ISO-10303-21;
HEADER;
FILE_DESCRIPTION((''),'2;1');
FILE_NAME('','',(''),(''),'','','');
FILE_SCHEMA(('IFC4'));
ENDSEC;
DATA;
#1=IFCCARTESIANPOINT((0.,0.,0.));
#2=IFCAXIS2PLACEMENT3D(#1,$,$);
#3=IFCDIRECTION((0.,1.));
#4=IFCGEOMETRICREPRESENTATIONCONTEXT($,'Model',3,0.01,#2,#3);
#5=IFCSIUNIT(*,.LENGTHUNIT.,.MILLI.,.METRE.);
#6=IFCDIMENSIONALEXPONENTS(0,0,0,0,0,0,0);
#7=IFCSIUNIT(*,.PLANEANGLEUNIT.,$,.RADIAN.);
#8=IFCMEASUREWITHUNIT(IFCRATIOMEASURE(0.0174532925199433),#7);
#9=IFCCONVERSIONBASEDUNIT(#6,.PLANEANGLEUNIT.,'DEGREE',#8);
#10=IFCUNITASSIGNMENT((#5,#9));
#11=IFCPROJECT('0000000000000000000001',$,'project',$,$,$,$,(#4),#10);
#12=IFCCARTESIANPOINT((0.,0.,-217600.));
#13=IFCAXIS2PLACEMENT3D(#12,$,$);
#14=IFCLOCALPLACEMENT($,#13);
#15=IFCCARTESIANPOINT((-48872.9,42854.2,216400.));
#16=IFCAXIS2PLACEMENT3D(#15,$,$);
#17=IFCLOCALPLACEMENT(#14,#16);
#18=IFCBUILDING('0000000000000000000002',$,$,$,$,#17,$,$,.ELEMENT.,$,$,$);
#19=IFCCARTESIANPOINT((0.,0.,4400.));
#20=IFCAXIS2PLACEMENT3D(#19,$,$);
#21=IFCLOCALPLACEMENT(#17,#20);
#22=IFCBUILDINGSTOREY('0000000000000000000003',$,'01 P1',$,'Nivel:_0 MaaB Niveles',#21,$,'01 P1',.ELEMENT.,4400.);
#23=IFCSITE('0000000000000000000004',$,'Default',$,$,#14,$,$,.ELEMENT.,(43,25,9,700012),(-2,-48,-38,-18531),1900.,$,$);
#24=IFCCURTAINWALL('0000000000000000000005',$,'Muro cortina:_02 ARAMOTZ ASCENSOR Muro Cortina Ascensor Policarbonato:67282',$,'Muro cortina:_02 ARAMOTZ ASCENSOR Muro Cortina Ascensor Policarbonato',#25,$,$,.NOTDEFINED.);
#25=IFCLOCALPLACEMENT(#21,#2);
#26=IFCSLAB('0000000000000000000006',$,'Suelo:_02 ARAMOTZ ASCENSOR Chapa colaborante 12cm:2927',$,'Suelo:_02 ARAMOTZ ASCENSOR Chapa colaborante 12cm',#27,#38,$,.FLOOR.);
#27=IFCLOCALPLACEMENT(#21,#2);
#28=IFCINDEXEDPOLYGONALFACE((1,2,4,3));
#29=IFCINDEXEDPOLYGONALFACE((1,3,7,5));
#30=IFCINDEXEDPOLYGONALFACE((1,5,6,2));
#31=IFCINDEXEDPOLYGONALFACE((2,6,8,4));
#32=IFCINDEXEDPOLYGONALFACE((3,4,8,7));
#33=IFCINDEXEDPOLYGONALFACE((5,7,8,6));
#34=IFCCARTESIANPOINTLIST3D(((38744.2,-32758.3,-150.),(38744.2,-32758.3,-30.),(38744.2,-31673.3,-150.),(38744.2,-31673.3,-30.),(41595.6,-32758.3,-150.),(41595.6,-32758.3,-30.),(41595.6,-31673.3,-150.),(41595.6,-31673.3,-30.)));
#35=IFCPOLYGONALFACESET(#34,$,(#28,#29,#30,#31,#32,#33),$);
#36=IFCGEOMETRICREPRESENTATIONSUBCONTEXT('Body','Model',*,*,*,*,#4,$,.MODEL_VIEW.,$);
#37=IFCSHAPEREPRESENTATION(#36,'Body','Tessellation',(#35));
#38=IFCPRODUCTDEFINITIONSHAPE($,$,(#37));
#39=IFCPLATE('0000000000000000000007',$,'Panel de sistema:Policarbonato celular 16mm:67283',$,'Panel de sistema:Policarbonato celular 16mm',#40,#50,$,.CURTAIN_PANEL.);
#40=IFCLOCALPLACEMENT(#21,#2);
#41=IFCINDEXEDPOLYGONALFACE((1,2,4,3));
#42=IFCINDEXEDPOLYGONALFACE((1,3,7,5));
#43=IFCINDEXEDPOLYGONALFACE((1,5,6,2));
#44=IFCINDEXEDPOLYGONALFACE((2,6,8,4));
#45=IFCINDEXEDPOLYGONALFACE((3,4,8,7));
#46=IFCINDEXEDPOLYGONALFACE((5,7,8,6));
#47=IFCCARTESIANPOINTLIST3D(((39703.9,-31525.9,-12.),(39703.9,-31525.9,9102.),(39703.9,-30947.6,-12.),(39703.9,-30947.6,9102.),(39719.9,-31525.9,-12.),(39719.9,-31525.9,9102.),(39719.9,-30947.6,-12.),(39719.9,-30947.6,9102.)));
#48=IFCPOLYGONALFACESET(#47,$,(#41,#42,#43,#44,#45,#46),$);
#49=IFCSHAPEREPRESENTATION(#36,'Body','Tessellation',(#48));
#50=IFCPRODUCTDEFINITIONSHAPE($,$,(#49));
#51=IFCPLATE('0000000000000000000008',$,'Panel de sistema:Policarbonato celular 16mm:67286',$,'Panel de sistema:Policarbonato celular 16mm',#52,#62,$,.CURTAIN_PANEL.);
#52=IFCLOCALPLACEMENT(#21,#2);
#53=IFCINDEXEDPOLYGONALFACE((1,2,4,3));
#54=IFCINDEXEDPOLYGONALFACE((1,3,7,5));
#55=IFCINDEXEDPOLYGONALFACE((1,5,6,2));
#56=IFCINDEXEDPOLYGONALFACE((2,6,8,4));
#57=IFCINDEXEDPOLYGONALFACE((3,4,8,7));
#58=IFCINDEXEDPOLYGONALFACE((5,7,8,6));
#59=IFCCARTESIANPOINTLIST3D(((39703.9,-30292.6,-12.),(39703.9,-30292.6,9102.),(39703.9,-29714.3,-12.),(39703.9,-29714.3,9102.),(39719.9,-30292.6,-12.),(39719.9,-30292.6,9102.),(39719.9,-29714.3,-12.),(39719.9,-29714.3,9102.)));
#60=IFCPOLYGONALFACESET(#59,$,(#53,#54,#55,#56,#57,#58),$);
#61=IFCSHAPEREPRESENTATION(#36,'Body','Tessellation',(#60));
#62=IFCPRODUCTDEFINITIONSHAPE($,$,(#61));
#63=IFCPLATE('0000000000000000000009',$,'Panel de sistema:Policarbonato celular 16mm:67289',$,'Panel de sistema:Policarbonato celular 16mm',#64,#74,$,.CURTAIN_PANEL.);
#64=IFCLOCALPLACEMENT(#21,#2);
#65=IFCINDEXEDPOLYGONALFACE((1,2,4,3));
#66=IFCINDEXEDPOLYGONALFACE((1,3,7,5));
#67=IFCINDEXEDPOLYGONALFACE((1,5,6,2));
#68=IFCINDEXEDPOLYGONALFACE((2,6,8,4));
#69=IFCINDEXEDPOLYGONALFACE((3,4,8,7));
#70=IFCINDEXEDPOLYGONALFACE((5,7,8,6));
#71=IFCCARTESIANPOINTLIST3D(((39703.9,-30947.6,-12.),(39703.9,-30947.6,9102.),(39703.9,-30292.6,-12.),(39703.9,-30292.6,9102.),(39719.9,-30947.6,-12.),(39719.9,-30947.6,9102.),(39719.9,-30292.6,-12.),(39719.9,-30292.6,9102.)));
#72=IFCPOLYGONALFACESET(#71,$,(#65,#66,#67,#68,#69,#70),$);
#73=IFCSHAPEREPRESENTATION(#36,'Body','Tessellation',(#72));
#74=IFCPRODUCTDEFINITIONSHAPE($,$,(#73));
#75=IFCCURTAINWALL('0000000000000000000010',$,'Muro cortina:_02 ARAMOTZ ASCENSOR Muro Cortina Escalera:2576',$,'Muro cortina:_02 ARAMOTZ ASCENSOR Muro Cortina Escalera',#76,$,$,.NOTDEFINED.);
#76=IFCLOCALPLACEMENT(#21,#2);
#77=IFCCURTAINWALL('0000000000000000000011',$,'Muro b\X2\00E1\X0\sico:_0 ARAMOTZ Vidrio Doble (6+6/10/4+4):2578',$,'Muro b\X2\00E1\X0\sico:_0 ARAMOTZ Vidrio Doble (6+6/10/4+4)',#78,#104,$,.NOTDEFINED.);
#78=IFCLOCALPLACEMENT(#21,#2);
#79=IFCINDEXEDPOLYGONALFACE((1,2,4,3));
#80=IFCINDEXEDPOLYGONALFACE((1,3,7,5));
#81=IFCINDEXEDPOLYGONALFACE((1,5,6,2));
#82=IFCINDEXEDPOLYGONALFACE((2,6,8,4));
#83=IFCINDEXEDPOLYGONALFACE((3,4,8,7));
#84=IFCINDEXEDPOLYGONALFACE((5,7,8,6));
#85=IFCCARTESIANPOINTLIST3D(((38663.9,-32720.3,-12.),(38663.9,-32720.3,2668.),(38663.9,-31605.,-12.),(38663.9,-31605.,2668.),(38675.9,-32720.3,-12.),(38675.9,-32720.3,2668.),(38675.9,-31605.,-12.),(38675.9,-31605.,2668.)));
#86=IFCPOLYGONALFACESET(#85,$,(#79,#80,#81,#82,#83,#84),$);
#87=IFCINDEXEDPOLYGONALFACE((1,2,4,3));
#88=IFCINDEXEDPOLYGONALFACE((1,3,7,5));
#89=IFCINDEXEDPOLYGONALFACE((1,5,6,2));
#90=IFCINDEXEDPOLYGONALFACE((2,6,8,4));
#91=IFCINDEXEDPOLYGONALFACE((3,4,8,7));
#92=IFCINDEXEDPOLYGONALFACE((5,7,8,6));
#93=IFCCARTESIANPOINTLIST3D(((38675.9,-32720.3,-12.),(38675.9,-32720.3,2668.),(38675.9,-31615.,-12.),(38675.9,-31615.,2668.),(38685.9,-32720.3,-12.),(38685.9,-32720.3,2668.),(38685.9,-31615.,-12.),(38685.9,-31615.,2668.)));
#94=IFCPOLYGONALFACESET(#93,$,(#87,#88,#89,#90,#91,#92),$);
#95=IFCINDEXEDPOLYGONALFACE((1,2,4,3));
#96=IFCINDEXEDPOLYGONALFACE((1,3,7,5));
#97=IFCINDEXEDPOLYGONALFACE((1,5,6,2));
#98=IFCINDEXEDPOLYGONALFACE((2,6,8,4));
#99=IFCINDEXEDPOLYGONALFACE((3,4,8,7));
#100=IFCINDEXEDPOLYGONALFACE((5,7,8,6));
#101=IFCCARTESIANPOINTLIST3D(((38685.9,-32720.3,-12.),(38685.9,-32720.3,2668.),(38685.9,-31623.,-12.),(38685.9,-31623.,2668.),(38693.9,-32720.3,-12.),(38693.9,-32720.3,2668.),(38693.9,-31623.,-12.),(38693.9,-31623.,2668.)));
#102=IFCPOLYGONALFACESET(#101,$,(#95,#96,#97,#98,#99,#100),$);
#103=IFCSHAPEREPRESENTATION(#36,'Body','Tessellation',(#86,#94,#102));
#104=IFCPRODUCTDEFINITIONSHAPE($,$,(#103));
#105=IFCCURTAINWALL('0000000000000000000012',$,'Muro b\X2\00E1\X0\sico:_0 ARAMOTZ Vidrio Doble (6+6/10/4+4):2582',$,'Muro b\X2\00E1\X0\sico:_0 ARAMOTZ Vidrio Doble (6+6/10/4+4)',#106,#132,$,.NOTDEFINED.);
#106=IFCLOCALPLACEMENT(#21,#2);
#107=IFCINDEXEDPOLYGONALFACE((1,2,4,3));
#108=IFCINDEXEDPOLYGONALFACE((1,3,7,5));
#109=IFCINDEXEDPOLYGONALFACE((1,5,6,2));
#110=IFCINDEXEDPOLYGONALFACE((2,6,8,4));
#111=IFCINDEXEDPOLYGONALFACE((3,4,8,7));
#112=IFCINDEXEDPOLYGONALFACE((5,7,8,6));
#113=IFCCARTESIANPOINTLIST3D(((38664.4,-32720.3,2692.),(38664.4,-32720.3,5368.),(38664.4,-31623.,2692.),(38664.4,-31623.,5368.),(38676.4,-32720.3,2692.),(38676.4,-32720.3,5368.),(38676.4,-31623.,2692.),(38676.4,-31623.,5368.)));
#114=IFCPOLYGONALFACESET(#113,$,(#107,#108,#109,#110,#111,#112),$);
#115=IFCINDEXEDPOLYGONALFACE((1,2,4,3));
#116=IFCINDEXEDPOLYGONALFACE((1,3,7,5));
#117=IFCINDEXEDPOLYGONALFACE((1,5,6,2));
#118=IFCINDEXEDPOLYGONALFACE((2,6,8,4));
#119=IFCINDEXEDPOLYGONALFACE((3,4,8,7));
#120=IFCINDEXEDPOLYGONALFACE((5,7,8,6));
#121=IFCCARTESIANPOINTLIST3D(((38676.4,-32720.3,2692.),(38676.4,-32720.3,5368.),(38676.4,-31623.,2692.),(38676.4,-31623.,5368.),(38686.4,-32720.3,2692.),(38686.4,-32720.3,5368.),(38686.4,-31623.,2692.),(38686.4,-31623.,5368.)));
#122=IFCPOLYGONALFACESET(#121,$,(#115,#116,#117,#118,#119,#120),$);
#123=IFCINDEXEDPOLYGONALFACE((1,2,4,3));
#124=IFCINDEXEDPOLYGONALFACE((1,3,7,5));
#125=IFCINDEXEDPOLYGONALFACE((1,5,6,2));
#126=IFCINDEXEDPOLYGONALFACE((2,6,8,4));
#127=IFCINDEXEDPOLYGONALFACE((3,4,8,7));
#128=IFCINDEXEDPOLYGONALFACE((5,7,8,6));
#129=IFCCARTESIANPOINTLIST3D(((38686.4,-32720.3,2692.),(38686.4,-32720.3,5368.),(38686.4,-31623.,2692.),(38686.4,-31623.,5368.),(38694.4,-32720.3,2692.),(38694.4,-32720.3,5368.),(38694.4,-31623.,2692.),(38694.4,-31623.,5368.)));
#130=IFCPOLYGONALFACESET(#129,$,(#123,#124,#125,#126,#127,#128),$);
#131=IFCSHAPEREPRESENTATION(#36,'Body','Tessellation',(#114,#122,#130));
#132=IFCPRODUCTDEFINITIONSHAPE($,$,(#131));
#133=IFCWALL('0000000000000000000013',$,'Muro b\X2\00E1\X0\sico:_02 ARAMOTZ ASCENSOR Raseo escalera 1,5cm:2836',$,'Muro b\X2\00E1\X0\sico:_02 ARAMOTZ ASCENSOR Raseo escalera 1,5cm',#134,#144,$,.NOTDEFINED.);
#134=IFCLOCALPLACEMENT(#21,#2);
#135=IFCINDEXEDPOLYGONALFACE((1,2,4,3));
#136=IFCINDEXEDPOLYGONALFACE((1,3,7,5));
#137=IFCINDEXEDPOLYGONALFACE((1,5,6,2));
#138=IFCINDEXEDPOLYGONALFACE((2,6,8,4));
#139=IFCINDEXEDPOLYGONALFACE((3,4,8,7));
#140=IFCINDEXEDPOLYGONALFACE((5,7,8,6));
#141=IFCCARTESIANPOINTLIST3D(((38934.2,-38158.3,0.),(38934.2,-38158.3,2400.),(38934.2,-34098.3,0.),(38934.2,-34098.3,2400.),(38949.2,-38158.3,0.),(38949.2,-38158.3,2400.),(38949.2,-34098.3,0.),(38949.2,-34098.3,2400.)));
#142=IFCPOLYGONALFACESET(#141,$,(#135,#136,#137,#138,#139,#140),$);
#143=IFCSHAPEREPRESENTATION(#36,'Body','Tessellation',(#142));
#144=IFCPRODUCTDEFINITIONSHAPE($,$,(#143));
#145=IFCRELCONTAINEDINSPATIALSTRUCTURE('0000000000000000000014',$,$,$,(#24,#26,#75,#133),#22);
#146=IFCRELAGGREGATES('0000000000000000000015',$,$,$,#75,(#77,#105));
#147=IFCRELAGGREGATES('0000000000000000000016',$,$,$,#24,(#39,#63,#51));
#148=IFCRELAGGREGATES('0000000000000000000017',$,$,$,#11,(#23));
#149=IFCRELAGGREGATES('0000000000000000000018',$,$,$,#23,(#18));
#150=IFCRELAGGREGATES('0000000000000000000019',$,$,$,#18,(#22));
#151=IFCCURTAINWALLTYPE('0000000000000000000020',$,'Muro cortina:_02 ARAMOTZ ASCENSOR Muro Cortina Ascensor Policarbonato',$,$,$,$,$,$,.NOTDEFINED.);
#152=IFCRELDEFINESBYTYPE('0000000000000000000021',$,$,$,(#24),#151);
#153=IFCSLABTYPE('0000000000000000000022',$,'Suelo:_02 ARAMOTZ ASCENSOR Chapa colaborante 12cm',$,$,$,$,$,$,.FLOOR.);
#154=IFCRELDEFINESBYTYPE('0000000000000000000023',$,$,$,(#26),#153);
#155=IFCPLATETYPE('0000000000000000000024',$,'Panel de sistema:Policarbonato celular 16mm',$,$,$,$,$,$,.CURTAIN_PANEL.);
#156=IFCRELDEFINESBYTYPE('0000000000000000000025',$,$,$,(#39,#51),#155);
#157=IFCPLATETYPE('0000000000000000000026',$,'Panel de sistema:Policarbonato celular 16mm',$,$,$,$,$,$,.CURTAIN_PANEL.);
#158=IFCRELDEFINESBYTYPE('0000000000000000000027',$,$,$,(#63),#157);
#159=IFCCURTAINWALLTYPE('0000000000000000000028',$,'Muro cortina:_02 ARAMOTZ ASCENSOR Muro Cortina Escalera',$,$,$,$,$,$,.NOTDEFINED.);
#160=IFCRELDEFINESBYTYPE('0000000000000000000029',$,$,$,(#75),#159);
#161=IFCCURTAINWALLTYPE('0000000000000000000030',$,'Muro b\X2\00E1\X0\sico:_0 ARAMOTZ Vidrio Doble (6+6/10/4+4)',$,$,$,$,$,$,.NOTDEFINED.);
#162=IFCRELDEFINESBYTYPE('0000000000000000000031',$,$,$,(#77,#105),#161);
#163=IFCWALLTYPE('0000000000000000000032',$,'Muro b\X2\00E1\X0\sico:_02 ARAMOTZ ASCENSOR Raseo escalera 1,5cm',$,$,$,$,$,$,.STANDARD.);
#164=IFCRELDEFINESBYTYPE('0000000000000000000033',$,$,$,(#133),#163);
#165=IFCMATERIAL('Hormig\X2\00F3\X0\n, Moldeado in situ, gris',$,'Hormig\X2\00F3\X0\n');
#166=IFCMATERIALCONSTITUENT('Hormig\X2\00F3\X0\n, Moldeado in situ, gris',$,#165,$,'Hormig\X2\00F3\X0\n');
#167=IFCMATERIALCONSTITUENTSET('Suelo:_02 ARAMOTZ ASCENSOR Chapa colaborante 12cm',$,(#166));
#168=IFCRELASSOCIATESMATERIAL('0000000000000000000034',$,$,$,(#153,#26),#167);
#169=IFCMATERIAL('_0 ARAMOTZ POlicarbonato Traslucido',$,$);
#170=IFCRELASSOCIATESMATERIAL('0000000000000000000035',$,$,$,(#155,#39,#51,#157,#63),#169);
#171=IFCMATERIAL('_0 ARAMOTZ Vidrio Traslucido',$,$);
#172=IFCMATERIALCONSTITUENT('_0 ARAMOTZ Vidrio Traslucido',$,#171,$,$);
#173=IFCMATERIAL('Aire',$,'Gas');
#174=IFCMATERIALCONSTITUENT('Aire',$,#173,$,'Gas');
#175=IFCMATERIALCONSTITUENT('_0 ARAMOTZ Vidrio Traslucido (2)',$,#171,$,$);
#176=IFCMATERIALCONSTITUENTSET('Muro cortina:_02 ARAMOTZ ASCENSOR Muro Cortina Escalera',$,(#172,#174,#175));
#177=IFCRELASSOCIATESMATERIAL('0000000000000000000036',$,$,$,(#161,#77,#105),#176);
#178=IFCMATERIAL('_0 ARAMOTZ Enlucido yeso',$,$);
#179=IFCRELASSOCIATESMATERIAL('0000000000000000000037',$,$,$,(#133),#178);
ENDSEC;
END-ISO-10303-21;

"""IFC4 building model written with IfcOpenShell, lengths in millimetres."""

from ifc_helpers import new_model, entity, si_unit, converted_unit, direction, frame, origin, place, context, subcontext, project, spatial, indexed_curve, outline, extrude, source, transform, mapped, material, constituent, constituent_set, type_object, type_shapes, element, aggregate, save


model = new_model("IFC4")

# Units and contexts
model_context = context("Model", 3, precision=0.01, world=origin(), true_north=direction((0.0, 1.0)))
body_context = subcontext(model_context, "Body", "Model", "MODEL_VIEW")
ifc_project = project(units=[si_unit("LENGTHUNIT", "METRE", prefix="MILLI"), converted_unit("PLANEANGLEUNIT", "DEGREE", entity("IfcRatioMeasure", 0.0174532925199433), si_unit("PLANEANGLEUNIT", "RADIAN"), dimensions=[0, 0, 0, 0, 0, 0, 0])], contexts=[model_context])

# Site, building, storey
site_placement = place(None, frame((0.0, 0.0, -217600.0)))
site = spatial("IfcSite", under=ifc_project, at=site_placement, Name="Default", CompositionType="ELEMENT", RefLatitude=(43, 25, 9, 700012), RefLongitude=(-2, -48, -38, -18531), RefElevation=1900.0)
building_placement = place(site_placement, frame((-48872.9, 42854.2, 216400.0)))
building = spatial("IfcBuilding", under=site, at=building_placement, CompositionType="ELEMENT")
storey_placement = place(building_placement, frame((0.0, 0.0, 4400.0)))
storey = spatial("IfcBuildingStorey", under=building, at=storey_placement, Name="01 P1", ObjectType="Nivel:_0 MaaB Niveles", LongName="01 P1", CompositionType="ELEMENT", Elevation=4400.0)

# Curtain wall
curtain_wall_type_1 = type_object("IfcCurtainWallType", Name="Muro cortina:_02 ARAMOTZ ASCENSOR Muro Cortina Ascensor Policarbonato", PredefinedType="NOTDEFINED")
curtain_wall_1_placement = place(storey_placement, frame((0.0, 0.0, -4400.0)))
curtain_wall_1 = element("IfcCurtainWall", 1, at=curtain_wall_1_placement, inside=storey, type_object=curtain_wall_type_1, Name="Muro cortina:_02 ARAMOTZ ASCENSOR Muro Cortina Ascensor Policarbonato:67282", ObjectType="Muro cortina:_02 ARAMOTZ ASCENSOR Muro Cortina Ascensor Policarbonato", PredefinedType="NOTDEFINED")

# Slab
ifc_material_1 = material(Name="Hormigón, Moldeado in situ, gris", Category="Hormigón")
ifc_constituent_1 = constituent(ifc_material_1, Name="Hormigón, Moldeado in situ, gris", Category="Hormigón")
ifc_constituent_set_1 = constituent_set(constituents=[ifc_constituent_1], Name="Suelo:_02 ARAMOTZ ASCENSOR Chapa colaborante 12cm")
slab_type_1 = type_object("IfcSlabType", Name="Suelo:_02 ARAMOTZ ASCENSOR Chapa colaborante 12cm", PredefinedType="FLOOR", material=ifc_constituent_set_1)
slab_1_placement = place(storey_placement, origin())
element("IfcSlab", 2, at=slab_1_placement, inside=storey, type_object=slab_type_1, material=ifc_constituent_set_1, Name="Suelo:_02 ARAMOTZ ASCENSOR Chapa colaborante 12cm:2927", ObjectType="Suelo:_02 ARAMOTZ ASCENSOR Chapa colaborante 12cm", PredefinedType="FLOOR", context=body_context, shape_type="SweptSolid", body=[
    extrude(outline(indexed_curve([(-542.5, -1425.7), (542.5, -1425.7), (542.5, 1425.7), (-542.5, 1425.7), (-542.5, -1425.7)], self_intersect=False)), frame((40169.9, -32215.8, -30.0), z_axis=(0.0, 0.0, -1.0), x_axis=(0.0, -1.0, 0.0)), (0.0, 0.0, 1.0), 120.0),
])

# Plates
ifc_material_2 = material(Name="_0 ARAMOTZ POlicarbonato Traslucido")
plate_type_1 = type_object("IfcPlateType", Name="Panel de sistema:Policarbonato celular 16mm", PredefinedType="CURTAIN_PANEL", material=ifc_material_2)
shared_shape_1 = source(origin(), body_context, "Body", "SweptSolid", [
    extrude(outline(indexed_curve([(-8.0, -289.1), (8.0, -289.1), (8.0, 289.1), (-8.0, 289.1), (-8.0, -289.1)], self_intersect=False)), frame((0.0, -8.0, 0.0), z_axis=(0.0, 0.0, 1.0), x_axis=(0.0, 1.0, 0.0)), (0.0, 0.0, 1.0), 9114.0),
])
type_shapes(plate_type_1, [shared_shape_1])
plate_1_placement = place(curtain_wall_1_placement, frame((39703.9, -31236.8, 4388.0), z_axis=(0.0, 0.0, 1.0), x_axis=(0.0, 1.0, 0.0)))
plate_1 = element("IfcPlate", 3, at=plate_1_placement, type_object=plate_type_1, material=ifc_material_2, Name="Panel de sistema:Policarbonato celular 16mm:67283", ObjectType="Panel de sistema:Policarbonato celular 16mm", PredefinedType="CURTAIN_PANEL", context=body_context, shape_type="MappedRepresentation", body=[
    mapped(shared_shape_1, transform((0.0, 0.0, 0.0), scale=1.0)),
])
plate_2_placement = place(curtain_wall_1_placement, frame((39703.9, -30003.5, 4388.0), z_axis=(0.0, 0.0, 1.0), x_axis=(0.0, 1.0, 0.0)))
plate_2 = element("IfcPlate", 4, at=plate_2_placement, type_object=plate_type_1, material=ifc_material_2, Name="Panel de sistema:Policarbonato celular 16mm:67286", ObjectType="Panel de sistema:Policarbonato celular 16mm", PredefinedType="CURTAIN_PANEL", context=body_context, shape_type="MappedRepresentation", body=[
    mapped(shared_shape_1, transform((0.0, 0.0, 0.0), scale=1.0)),
])
plate_type_2 = type_object("IfcPlateType", Name="Panel de sistema:Policarbonato celular 16mm", PredefinedType="CURTAIN_PANEL", material=ifc_material_2)
shared_shape_2 = source(origin(), body_context, "Body", "SweptSolid", [
    extrude(outline(indexed_curve([(-8.0, -327.5), (8.0, -327.5), (8.0, 327.5), (-8.0, 327.5), (-8.0, -327.5)], self_intersect=False)), frame((0.0, -8.0, 0.0), z_axis=(0.0, 0.0, 1.0), x_axis=(0.0, 1.0, 0.0)), (0.0, 0.0, 1.0), 9114.0),
])
type_shapes(plate_type_2, [shared_shape_2])
plate_3_placement = place(curtain_wall_1_placement, frame((39703.9, -30620.1, 4388.0), z_axis=(0.0, 0.0, 1.0), x_axis=(0.0, 1.0, 0.0)))
plate_3 = element("IfcPlate", 5, at=plate_3_placement, type_object=plate_type_2, material=ifc_material_2, Name="Panel de sistema:Policarbonato celular 16mm:67289", ObjectType="Panel de sistema:Policarbonato celular 16mm", PredefinedType="CURTAIN_PANEL", context=body_context, shape_type="MappedRepresentation", body=[
    mapped(shared_shape_2, transform((0.0, 0.0, 0.0), scale=1.0)),
])

# Curtain walls
curtain_wall_type_2 = type_object("IfcCurtainWallType", Name="Muro cortina:_02 ARAMOTZ ASCENSOR Muro Cortina Escalera", PredefinedType="NOTDEFINED")
ifc_material_3 = material(Name="_0 ARAMOTZ Vidrio Traslucido")
ifc_constituent_2 = constituent(ifc_material_3, Name="_0 ARAMOTZ Vidrio Traslucido")
ifc_material_4 = material(Name="Aire", Category="Gas")
ifc_constituent_3 = constituent(ifc_material_4, Name="Aire", Category="Gas")
ifc_constituent_4 = constituent(ifc_material_3, Name="_0 ARAMOTZ Vidrio Traslucido (2)")
ifc_constituent_set_2 = constituent_set(constituents=[ifc_constituent_2, ifc_constituent_3, ifc_constituent_4], Name="Muro cortina:_02 ARAMOTZ ASCENSOR Muro Cortina Escalera")
curtain_wall_type_3 = type_object("IfcCurtainWallType", Name="Muro básico:_0 ARAMOTZ Vidrio Doble (6+6/10/4+4)", PredefinedType="NOTDEFINED", material=ifc_constituent_set_2)
placement = place(building_placement, frame((0.0, 0.0, 7100.0)))
curtain_wall_2_placement = place(storey_placement, frame((0.0, 0.0, -4400.0)))
curtain_wall_2 = element("IfcCurtainWall", 6, at=curtain_wall_2_placement, inside=storey, type_object=curtain_wall_type_2, Name="Muro cortina:_02 ARAMOTZ ASCENSOR Muro Cortina Escalera:2576", ObjectType="Muro cortina:_02 ARAMOTZ ASCENSOR Muro Cortina Escalera", PredefinedType="NOTDEFINED")
curtain_wall_3_placement = place(storey_placement, frame((38678.9, -32720.3, -12.0), z_axis=(0.0, 0.0, 1.0), x_axis=(0.0, 1.0, 0.0)))
curtain_wall_3 = element("IfcCurtainWall", 7, at=curtain_wall_3_placement, type_object=curtain_wall_type_3, material=ifc_constituent_set_2, Name="Muro básico:_0 ARAMOTZ Vidrio Doble (6+6/10/4+4):2578", ObjectType="Muro básico:_0 ARAMOTZ Vidrio Doble (6+6/10/4+4)", PredefinedType="NOTDEFINED", context=body_context, shape_type="SweptSolid", body=[
    extrude(outline(indexed_curve([(-6.0, -557.7), (6.0, -557.7), (6.0, 557.7), (-6.0, 557.7), (-6.0, -557.7)], self_intersect=False)), frame((557.7, 9.0, 0.0), z_axis=(0.0, 0.0, 1.0), x_axis=(0.0, -1.0, 0.0)), (0.0, 0.0, 1.0), 2680.0),
    extrude(outline(indexed_curve([(-5.0, -552.7), (5.0, -552.7), (5.0, 552.7), (-5.0, 552.7), (-5.0, -552.7)], self_intersect=False)), frame((552.7, -2.0, 0.0), z_axis=(0.0, 0.0, 1.0), x_axis=(0.0, -1.0, 0.0)), (0.0, 0.0, 1.0), 2680.0),
    extrude(outline(indexed_curve([(-4.0, -548.7), (4.0, -548.7), (4.0, 548.7), (-4.0, 548.7), (-4.0, -548.7)], self_intersect=False)), frame((548.7, -11.0, 0.0), z_axis=(0.0, 0.0, 1.0), x_axis=(0.0, -1.0, 0.0)), (0.0, 0.0, 1.0), 2680.0),
])
curtain_wall_4_placement = place(placement, frame((38679.4, -32720.3, -8.0), z_axis=(0.0, 0.0, 1.0), x_axis=(0.0, 1.0, 0.0)))
curtain_wall_4 = element("IfcCurtainWall", 8, at=curtain_wall_4_placement, type_object=curtain_wall_type_3, material=ifc_constituent_set_2, Name="Muro básico:_0 ARAMOTZ Vidrio Doble (6+6/10/4+4):2582", ObjectType="Muro básico:_0 ARAMOTZ Vidrio Doble (6+6/10/4+4)", PredefinedType="NOTDEFINED", context=body_context, shape_type="SweptSolid", body=[
    extrude(outline(indexed_curve([(-6.0, -548.7), (6.0, -548.7), (6.0, 548.7), (-6.0, 548.7), (-6.0, -548.7)], self_intersect=False)), frame((548.7, 9.0, 0.0), z_axis=(0.0, 0.0, 1.0), x_axis=(0.0, -1.0, 0.0)), (0.0, 0.0, 1.0), 2676.0),
    extrude(outline(indexed_curve([(-5.0, -548.7), (5.0, -548.7), (5.0, 548.7), (-5.0, 548.7), (-5.0, -548.7)], self_intersect=False)), frame((548.7, -2.0, 0.0), z_axis=(0.0, 0.0, 1.0), x_axis=(0.0, -1.0, 0.0)), (0.0, 0.0, 1.0), 2676.0),
    extrude(outline(indexed_curve([(-4.0, -548.7), (4.0, -548.7), (4.0, 548.7), (-4.0, 548.7), (-4.0, -548.7)], self_intersect=False)), frame((548.7, -11.0, 0.0), z_axis=(0.0, 0.0, 1.0), x_axis=(0.0, -1.0, 0.0)), (0.0, 0.0, 1.0), 2676.0),
])

# Wall
ifc_material_5 = material(Name="_0 ARAMOTZ Enlucido yeso")
wall_type_1 = type_object("IfcWallType", Name="Muro básico:_02 ARAMOTZ ASCENSOR Raseo escalera 1,5cm", PredefinedType="STANDARD")
wall_1_placement = place(storey_placement, frame((38941.7, -38158.3, 0.0), z_axis=(0.0, 0.0, 1.0), x_axis=(0.0, 1.0, 0.0)))
element("IfcWall", 9, at=wall_1_placement, inside=storey, type_object=wall_type_1, material=ifc_material_5, Name="Muro básico:_02 ARAMOTZ ASCENSOR Raseo escalera 1,5cm:2836", ObjectType="Muro básico:_02 ARAMOTZ ASCENSOR Raseo escalera 1,5cm", PredefinedType="NOTDEFINED", context=body_context, shape_type="SweptSolid", body=[
    extrude(outline(indexed_curve([(4060.0, 7.5), (0.0, 7.5), (0.0, -7.5), (4060.0, -7.5), (4060.0, 7.5)], self_intersect=False)), origin(), (0.0, 0.0, 1.0), 2400.0),
])

aggregate(curtain_wall_2, [curtain_wall_3, curtain_wall_4])
aggregate(curtain_wall_1, [plate_1, plate_3, plate_2])

save(model, "model.ifc")
